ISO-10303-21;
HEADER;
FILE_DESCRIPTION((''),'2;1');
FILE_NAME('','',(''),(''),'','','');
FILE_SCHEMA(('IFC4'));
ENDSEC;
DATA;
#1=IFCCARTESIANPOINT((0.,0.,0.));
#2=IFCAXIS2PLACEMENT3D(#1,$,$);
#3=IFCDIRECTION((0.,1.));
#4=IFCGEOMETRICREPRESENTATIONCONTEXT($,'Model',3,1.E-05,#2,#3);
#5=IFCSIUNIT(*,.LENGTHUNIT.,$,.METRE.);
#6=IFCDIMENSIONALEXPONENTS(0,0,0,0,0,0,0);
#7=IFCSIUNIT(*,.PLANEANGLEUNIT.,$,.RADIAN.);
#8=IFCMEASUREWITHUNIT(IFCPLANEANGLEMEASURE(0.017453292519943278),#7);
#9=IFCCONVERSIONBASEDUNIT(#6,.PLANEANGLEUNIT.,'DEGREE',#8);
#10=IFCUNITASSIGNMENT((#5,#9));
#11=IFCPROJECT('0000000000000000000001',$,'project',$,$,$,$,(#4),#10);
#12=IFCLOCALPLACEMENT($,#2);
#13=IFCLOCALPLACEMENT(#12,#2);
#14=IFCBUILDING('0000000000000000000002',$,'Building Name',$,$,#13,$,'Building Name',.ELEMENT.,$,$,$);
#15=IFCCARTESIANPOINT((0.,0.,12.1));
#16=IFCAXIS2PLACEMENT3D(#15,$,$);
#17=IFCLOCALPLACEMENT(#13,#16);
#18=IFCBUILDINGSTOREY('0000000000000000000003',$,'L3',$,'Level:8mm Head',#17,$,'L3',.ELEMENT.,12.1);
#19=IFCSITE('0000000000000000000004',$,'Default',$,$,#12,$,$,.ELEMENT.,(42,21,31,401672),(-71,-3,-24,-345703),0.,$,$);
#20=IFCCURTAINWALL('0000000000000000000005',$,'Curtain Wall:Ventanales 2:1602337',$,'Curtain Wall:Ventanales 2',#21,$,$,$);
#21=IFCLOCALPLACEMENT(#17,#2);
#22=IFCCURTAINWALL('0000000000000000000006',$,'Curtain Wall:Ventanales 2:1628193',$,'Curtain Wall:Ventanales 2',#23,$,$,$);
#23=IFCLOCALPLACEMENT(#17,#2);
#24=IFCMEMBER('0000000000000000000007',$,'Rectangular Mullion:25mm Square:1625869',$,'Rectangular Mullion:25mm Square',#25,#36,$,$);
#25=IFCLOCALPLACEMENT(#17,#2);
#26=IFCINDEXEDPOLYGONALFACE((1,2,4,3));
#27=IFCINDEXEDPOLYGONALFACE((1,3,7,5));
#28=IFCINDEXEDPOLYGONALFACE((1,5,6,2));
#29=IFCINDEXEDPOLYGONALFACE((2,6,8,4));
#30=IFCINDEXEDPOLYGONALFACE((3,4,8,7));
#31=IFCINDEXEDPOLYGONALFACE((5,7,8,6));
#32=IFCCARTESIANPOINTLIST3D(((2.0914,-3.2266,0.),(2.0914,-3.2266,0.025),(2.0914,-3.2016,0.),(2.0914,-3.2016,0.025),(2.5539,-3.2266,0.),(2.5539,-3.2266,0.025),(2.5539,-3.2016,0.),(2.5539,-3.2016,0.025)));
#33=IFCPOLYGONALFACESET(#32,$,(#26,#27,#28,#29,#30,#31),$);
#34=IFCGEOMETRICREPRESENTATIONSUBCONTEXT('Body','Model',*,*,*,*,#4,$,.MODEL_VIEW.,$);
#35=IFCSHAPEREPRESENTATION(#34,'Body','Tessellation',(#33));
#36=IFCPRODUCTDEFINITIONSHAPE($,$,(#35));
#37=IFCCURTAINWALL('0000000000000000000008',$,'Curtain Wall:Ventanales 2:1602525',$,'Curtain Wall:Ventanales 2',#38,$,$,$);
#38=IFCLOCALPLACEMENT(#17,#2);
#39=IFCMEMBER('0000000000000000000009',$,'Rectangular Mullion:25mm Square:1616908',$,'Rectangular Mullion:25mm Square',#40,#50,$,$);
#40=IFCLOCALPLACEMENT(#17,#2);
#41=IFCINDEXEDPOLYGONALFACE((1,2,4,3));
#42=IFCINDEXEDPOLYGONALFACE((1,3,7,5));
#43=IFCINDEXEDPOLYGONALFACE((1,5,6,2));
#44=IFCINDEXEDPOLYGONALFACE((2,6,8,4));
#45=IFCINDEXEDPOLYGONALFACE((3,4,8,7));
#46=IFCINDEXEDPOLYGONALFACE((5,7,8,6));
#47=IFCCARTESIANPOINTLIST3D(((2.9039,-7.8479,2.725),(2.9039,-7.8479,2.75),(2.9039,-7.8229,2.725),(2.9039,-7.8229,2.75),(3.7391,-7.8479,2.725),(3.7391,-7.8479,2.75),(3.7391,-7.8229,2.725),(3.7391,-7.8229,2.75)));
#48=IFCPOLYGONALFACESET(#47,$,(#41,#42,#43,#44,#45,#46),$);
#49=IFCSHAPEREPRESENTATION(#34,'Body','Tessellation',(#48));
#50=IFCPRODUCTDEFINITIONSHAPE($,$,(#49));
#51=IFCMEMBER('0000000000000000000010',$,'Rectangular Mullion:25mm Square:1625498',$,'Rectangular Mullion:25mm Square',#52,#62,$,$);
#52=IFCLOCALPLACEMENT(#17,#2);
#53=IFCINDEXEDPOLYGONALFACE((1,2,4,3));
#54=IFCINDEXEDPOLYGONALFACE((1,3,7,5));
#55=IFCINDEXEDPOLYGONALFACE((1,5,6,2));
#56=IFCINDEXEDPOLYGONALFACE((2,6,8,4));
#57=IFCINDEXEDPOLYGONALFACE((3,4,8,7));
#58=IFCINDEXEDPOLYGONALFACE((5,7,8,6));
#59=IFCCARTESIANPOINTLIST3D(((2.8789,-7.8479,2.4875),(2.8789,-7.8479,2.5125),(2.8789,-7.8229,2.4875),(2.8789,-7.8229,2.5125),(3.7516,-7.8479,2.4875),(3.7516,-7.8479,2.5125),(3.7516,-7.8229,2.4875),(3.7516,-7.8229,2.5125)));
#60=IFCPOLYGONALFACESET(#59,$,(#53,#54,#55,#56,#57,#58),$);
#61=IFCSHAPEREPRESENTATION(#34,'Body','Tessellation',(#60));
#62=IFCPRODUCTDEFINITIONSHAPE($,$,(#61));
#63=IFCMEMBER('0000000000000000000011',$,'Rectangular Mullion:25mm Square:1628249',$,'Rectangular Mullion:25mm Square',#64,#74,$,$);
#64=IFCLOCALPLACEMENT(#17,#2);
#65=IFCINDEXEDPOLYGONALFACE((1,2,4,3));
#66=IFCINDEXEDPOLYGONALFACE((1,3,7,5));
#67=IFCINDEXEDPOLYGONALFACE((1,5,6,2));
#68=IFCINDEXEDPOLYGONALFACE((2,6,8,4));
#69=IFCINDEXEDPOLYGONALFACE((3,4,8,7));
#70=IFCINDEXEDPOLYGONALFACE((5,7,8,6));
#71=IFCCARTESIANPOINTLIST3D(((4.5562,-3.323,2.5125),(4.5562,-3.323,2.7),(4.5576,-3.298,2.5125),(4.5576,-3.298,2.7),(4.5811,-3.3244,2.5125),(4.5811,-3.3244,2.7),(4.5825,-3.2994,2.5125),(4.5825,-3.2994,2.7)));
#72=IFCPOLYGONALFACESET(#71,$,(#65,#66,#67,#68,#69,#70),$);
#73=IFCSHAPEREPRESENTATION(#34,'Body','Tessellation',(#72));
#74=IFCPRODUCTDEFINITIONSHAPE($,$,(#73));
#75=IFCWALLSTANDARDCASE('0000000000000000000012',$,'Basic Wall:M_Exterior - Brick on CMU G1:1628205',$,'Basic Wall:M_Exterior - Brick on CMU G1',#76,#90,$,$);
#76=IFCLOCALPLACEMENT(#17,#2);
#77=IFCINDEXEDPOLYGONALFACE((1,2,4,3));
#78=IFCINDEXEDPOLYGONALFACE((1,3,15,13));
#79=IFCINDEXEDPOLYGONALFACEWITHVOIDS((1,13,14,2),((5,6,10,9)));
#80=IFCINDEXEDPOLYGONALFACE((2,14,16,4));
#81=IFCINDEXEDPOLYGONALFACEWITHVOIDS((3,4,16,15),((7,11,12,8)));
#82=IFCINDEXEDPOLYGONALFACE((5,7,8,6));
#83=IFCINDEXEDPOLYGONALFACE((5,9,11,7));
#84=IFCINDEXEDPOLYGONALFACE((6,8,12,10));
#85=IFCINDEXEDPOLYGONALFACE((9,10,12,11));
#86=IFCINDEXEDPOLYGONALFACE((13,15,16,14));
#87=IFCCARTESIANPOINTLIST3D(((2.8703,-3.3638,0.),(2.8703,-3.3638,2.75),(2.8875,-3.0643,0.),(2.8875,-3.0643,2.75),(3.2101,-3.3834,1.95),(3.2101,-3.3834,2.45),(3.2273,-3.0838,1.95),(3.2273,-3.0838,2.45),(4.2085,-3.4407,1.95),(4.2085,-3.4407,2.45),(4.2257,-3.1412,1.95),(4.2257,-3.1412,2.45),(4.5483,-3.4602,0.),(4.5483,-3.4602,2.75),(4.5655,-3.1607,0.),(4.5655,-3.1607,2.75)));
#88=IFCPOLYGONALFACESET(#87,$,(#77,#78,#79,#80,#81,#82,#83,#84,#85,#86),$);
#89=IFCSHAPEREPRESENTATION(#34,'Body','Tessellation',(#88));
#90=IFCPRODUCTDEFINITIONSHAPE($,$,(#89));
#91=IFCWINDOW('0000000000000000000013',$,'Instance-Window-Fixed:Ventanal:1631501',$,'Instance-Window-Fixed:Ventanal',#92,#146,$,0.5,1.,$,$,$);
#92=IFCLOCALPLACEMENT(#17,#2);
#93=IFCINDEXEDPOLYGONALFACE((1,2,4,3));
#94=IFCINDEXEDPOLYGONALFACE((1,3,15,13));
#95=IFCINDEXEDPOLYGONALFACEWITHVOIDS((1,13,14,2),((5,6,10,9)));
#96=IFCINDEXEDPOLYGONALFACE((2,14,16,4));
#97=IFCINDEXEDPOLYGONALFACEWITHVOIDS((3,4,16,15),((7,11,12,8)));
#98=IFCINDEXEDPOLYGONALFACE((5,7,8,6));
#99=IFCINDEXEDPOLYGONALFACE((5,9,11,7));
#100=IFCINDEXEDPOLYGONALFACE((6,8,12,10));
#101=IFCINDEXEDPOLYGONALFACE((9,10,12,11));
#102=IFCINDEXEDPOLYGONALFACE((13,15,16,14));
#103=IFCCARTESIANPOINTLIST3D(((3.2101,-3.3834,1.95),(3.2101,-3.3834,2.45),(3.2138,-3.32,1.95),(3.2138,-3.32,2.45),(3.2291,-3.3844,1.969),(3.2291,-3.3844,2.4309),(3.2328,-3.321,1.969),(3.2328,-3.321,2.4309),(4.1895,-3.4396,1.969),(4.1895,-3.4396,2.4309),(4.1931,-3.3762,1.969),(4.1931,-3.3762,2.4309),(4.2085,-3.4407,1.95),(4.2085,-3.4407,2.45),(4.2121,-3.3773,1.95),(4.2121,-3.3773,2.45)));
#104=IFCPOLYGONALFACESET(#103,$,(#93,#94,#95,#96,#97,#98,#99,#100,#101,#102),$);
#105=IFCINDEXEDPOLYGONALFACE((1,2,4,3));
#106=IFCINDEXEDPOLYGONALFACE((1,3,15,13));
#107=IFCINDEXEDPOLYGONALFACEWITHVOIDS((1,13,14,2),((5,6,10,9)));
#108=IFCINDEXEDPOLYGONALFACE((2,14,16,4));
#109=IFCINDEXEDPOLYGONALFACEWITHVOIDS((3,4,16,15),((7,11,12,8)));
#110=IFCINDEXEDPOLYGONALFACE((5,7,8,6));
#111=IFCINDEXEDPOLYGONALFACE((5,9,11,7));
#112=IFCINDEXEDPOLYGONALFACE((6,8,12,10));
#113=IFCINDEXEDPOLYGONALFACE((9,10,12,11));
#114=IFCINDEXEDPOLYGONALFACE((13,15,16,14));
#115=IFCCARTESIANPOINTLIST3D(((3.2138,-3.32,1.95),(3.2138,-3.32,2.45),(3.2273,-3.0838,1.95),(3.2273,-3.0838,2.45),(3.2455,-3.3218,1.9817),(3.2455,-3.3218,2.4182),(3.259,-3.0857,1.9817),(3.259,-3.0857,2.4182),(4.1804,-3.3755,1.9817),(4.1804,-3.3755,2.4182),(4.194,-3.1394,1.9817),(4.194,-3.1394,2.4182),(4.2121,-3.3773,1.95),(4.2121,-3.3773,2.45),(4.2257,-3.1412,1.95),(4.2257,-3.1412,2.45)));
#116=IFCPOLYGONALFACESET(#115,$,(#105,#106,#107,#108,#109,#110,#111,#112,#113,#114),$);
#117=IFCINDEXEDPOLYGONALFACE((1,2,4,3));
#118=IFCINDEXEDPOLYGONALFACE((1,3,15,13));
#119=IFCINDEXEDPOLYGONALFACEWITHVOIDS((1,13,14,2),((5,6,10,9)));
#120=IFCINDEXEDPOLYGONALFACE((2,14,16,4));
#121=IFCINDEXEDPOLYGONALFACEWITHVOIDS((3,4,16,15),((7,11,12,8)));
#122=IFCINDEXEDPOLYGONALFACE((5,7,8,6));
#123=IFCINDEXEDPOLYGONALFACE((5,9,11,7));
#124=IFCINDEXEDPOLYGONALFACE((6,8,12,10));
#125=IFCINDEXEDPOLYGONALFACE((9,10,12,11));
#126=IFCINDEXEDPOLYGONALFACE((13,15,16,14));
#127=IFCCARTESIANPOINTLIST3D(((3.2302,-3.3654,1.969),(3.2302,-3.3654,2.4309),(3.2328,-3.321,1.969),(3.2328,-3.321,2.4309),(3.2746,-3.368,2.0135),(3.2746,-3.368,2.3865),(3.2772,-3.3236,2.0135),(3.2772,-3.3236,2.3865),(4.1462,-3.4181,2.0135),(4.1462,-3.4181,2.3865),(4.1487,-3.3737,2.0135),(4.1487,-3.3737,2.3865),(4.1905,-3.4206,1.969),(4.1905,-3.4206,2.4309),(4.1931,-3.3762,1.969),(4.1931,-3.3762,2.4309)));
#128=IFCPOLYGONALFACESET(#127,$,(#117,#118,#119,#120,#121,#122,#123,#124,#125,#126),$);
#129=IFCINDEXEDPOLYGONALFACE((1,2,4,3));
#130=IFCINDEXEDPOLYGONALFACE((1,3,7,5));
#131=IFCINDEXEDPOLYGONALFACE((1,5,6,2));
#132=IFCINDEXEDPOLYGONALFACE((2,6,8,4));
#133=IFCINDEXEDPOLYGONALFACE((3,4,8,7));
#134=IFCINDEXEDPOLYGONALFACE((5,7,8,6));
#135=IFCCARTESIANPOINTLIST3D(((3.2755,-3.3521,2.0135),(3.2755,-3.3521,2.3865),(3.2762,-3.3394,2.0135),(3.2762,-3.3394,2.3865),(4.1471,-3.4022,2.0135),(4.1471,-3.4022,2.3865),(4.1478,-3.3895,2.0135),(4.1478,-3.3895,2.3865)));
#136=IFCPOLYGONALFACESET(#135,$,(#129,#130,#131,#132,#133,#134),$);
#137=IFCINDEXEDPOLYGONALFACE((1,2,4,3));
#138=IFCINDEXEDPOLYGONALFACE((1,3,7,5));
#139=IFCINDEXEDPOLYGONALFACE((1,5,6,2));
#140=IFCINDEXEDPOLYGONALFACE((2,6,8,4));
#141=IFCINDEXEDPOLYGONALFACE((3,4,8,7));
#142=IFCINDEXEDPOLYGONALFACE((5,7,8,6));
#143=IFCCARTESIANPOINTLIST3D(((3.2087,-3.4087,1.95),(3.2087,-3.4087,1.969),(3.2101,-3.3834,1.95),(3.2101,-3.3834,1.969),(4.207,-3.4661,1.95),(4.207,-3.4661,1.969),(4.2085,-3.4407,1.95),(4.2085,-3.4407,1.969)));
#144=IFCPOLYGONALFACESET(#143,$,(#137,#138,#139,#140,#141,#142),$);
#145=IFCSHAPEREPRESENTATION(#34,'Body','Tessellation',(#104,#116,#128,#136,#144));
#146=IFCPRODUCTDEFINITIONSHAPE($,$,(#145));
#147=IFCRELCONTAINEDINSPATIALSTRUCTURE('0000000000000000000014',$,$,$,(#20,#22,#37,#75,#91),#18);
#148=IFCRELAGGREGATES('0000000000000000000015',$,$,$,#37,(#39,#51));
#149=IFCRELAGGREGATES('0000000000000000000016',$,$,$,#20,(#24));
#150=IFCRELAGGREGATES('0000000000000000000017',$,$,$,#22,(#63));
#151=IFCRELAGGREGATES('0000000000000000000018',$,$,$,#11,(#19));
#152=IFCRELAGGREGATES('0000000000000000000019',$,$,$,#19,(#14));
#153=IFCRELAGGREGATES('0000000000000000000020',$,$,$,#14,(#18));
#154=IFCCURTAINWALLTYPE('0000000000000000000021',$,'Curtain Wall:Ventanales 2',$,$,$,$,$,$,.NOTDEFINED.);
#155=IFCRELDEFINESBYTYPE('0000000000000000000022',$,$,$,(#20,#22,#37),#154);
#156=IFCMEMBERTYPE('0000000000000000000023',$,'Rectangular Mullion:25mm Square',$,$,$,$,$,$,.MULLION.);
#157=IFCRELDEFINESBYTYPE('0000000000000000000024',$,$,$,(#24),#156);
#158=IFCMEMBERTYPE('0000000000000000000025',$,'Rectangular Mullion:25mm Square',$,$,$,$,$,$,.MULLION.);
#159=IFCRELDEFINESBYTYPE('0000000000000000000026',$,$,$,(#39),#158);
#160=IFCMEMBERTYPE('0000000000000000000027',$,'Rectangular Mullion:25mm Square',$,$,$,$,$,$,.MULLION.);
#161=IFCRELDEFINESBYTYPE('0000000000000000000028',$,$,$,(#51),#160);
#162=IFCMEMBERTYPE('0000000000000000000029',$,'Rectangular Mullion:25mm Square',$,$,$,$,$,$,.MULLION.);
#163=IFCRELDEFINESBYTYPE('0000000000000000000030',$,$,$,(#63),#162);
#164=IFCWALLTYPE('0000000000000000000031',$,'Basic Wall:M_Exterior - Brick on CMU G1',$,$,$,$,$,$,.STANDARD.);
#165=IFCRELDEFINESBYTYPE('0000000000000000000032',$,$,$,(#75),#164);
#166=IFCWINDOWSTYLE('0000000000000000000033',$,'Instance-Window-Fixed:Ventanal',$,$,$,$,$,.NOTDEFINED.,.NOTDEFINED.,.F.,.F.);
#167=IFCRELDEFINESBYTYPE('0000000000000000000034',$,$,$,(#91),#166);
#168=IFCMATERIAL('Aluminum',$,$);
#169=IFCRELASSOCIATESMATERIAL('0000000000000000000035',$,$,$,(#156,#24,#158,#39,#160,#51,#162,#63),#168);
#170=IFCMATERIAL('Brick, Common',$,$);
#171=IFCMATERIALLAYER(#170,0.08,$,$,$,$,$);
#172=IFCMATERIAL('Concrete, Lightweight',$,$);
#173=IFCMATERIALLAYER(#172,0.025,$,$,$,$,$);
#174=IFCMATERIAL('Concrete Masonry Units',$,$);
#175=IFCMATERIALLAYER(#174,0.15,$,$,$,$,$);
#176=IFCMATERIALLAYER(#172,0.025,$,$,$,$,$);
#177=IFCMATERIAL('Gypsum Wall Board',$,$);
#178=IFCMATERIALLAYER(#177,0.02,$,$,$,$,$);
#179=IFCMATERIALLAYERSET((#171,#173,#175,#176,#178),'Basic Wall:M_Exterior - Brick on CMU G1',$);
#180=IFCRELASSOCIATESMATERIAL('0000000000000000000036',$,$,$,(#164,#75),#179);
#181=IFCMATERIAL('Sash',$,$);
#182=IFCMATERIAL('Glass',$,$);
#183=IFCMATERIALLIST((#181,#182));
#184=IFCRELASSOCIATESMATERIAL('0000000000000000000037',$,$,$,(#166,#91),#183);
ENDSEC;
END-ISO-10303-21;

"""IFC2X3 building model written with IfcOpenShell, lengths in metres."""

from ifc_helpers import new_model, entity, si_unit, converted_unit, direction, frame, frame_2d, origin, origin_2d_with_axis, place, context, subcontext, project, spatial, polyline, rectangle, outline, extrude, source, transform, mapped, material, material_list, layer, layer_set, layer_usage, type_object, type_shapes, element, fill, aggregate, save


model = new_model("IFC2X3")

# Units and contexts
model_context = context("Model", 3, precision=1e-05, world=origin(), true_north=direction((0.0, 1.0)))
body_context = subcontext(model_context, "Body", "Model", "MODEL_VIEW")
ifc_project = project(units=[si_unit("LENGTHUNIT", "METRE"), converted_unit("PLANEANGLEUNIT", "DEGREE", entity("IfcPlaneAngleMeasure", 0.017453292519943278), si_unit("PLANEANGLEUNIT", "RADIAN"), dimensions=[0, 0, 0, 0, 0, 0, 0])], contexts=[model_context])

# Site, building, storey
site_placement = place(None, origin())
site = spatial("IfcSite", under=ifc_project, at=site_placement, Name="Default", CompositionType="ELEMENT", RefLatitude=(42, 21, 31, 401672), RefLongitude=(-71, -3, -24, -345703), RefElevation=0.0)
building_placement = place(site_placement, origin())
building = spatial("IfcBuilding", under=site, at=building_placement, Name="Building Name", LongName="Building Name", CompositionType="ELEMENT")
storey_placement = place(building_placement, frame((0.0, 0.0, 12.1)))
storey = spatial("IfcBuildingStorey", under=building, at=storey_placement, Name="L3", ObjectType="Level:8mm Head", LongName="L3", CompositionType="ELEMENT", Elevation=12.1)

# Curtain wall
curtain_wall_type = type_object("IfcCurtainWallType", Name="Curtain Wall:Ventanales 2", PredefinedType="NOTDEFINED")
curtain_wall_1_placement = place(storey_placement, frame((0.0, 0.0, -12.1)))
curtain_wall_1 = element("IfcCurtainWall", 1, at=curtain_wall_1_placement, inside=storey, type_object=curtain_wall_type, Name="Curtain Wall:Ventanales 2:1602337", ObjectType="Curtain Wall:Ventanales 2")
ifc_material_1 = material(Name="Aluminum")

# Curtain wall
curtain_wall_2_placement = place(storey_placement, frame((0.0, 0.0, -12.1)))
curtain_wall_2 = element("IfcCurtainWall", 2, at=curtain_wall_2_placement, inside=storey, type_object=curtain_wall_type, Name="Curtain Wall:Ventanales 2:1628193", ObjectType="Curtain Wall:Ventanales 2")

# Member
member_type_1 = type_object("IfcMemberType", Name="Rectangular Mullion:25mm Square", PredefinedType="MULLION", material=ifc_material_1)
shared_shape_1 = source(origin(), body_context, "Body", "SweptSolid", [
    extrude(rectangle(XDim=0.025, YDim=0.025, at=origin_2d_with_axis()), frame((-0.0125, 0.0, -0.4625), z_axis=(0.0, 0.0, 1.0), x_axis=(-1.0, 0.0, 0.0)), (0.0, 0.0, 1.0), 0.4625),
])
type_shapes(member_type_1, [shared_shape_1])
member_1_placement = place(curtain_wall_1_placement, frame((2.0914, -3.2141, 12.1), z_axis=(-1.0, 0.0, 0.0), x_axis=(0.0, 0.0, -1.0)))
member_1 = element("IfcMember", 3, at=member_1_placement, type_object=member_type_1, material=ifc_material_1, Name="Rectangular Mullion:25mm Square:1625869", ObjectType="Rectangular Mullion:25mm Square", context=body_context, shape_type="MappedRepresentation", body=[
    mapped(shared_shape_1, transform((0.0, 0.0, 0.0), scale=1.0)),
])

# Curtain wall, members
curtain_wall_3_placement = place(storey_placement, frame((0.0, 0.0, -12.1)))
curtain_wall_3 = element("IfcCurtainWall", 4, at=curtain_wall_3_placement, inside=storey, type_object=curtain_wall_type, Name="Curtain Wall:Ventanales 2:1602525", ObjectType="Curtain Wall:Ventanales 2")
member_type_2 = type_object("IfcMemberType", Name="Rectangular Mullion:25mm Square", PredefinedType="MULLION", material=ifc_material_1)
shared_shape_2 = source(origin(), body_context, "Body", "SweptSolid", [
    extrude(rectangle(XDim=0.025, YDim=0.025, at=origin_2d_with_axis()), frame((-0.0125, 0.0, -0.8352), z_axis=(0.0, 0.0, 1.0), x_axis=(-1.0, 0.0, 0.0)), (0.0, 0.0, 1.0), 0.8352),
])
type_shapes(member_type_2, [shared_shape_2])
member_2_placement = place(curtain_wall_3_placement, frame((2.9039, -7.8354, 14.85), z_axis=(-1.0, 0.0, 0.0), x_axis=(0.0, 0.0, 1.0)))
member_2 = element("IfcMember", 5, at=member_2_placement, type_object=member_type_2, material=ifc_material_1, Name="Rectangular Mullion:25mm Square:1616908", ObjectType="Rectangular Mullion:25mm Square", context=body_context, shape_type="MappedRepresentation", body=[
    mapped(shared_shape_2, transform((0.0, 0.0, 0.0), scale=1.0)),
])
member_type_3 = type_object("IfcMemberType", Name="Rectangular Mullion:25mm Square", PredefinedType="MULLION", material=ifc_material_1)
shared_shape_3 = source(origin(), body_context, "Body", "SweptSolid", [
    extrude(rectangle(XDim=0.025, YDim=0.025, at=frame_2d((0.0, 0.0), x_axis=(1.0, 0.0))), frame((0.0, 0.0, -0.8727), z_axis=(0.0, 0.0, 1.0), x_axis=(-1.0, 0.0, 0.0)), (0.0, 0.0, 1.0), 0.8727),
])
type_shapes(member_type_3, [shared_shape_3])
member_3_placement = place(curtain_wall_3_placement, frame((2.8789, -7.8354, 14.6), z_axis=(-1.0, 0.0, 0.0), x_axis=(0.0, 0.0, 1.0)))
member_3 = element("IfcMember", 6, at=member_3_placement, type_object=member_type_3, material=ifc_material_1, Name="Rectangular Mullion:25mm Square:1625498", ObjectType="Rectangular Mullion:25mm Square", context=body_context, shape_type="MappedRepresentation", body=[
    mapped(shared_shape_3, transform((0.0, 0.0, 0.0), scale=1.0)),
])
aggregate(curtain_wall_3, [member_2, member_3])

# Member
member_type_4 = type_object("IfcMemberType", Name="Rectangular Mullion:25mm Square", PredefinedType="MULLION", material=ifc_material_1)
shared_shape_4 = source(origin(), body_context, "Body", "SweptSolid", [
    extrude(rectangle(XDim=0.025, YDim=0.025, at=origin_2d_with_axis()), frame((-0.0125, 0.0, -0.1875), z_axis=(0.0, 0.0, 1.0), x_axis=(-1.0, 0.0, 0.0)), (0.0, 0.0, 1.0), 0.1875),
])
type_shapes(member_type_4, [shared_shape_4])
member_4_placement = place(curtain_wall_2_placement, frame((4.5569, -3.3105, 14.8), z_axis=(0.0, 0.0, 1.0), x_axis=(-0.998353, 0.057365, 0.0)))
member_4 = element("IfcMember", 7, at=member_4_placement, type_object=member_type_4, material=ifc_material_1, Name="Rectangular Mullion:25mm Square:1628249", ObjectType="Rectangular Mullion:25mm Square", context=body_context, shape_type="MappedRepresentation", body=[
    mapped(shared_shape_4, transform((0.0, 0.0, 0.0), scale=1.0)),
])

# Shared definitions
ifc_material_2 = material(Name="Glass")
aggregate(curtain_wall_1, [member_1])
aggregate(curtain_wall_2, [member_4])

# Wall, opening, window
ifc_material_3 = material(Name="Brick, Common")
ifc_layer_1 = layer(ifc_material_3, 0.08)
ifc_material_4 = material(Name="Concrete, Lightweight")
ifc_layer_2 = layer(ifc_material_4, 0.025)
ifc_material_5 = material(Name="Concrete Masonry Units")
ifc_layer_3 = layer(ifc_material_5, 0.15)
ifc_layer_4 = layer(ifc_material_4, 0.025)
ifc_material_6 = material(Name="Gypsum Wall Board")
ifc_layer_5 = layer(ifc_material_6, 0.02)
ifc_layer_set = layer_set([ifc_layer_1, ifc_layer_2, ifc_layer_3, ifc_layer_4, ifc_layer_5], Name="Basic Wall:M_Exterior - Brick on CMU G1")
ifc_layer_usage = layer_usage(ifc_layer_set, "AXIS2", "NEGATIVE", 0.15)
wall_type = type_object("IfcWallType", Name="Basic Wall:M_Exterior - Brick on CMU G1", PredefinedType="STANDARD", material=ifc_layer_set)
wall_placement = place(storey_placement, frame((2.8789, -3.2141, 0.0), z_axis=(0.0, 0.0, 1.0), x_axis=(0.998353, -0.057365, 0.0)))
wall = element("IfcWallStandardCase", 8, at=wall_placement, inside=storey, type_object=wall_type, material=ifc_layer_usage, Name="Basic Wall:M_Exterior - Brick on CMU G1:1628205", ObjectType="Basic Wall:M_Exterior - Brick on CMU G1", context=body_context, shape_type="SweptSolid", body=[
    extrude(rectangle(XDim=1.6807, YDim=0.3, at=frame_2d((0.8404, 0.0), x_axis=(-1.0, 0.0))), origin(), (0.0, 0.0, 1.0), 2.75),
])
opening_placement = place(wall_placement, frame((1.3404, 0.15, 1.95)))
opening = element("IfcOpeningElement", 9, at=opening_placement, cuts=wall, ObjectType="Opening", context=body_context, shape_type="SweptSolid", body=[
    extrude(rectangle(XDim=0.5, YDim=1.0, at=frame_2d((0.25, 0.5), x_axis=(-1.0, 0.0))), frame((0.0, 0.0, 0.0), z_axis=(0.0, -1.0, 0.0), x_axis=(0.0, 0.0, 1.0)), (0.0, 0.0, 1.0), 0.3),
])
ifc_material_7 = material(Name="Sash")
ifc_material_list = material_list([ifc_material_7, ifc_material_2])
window_style = type_object("IfcWindowStyle", Name="Instance-Window-Fixed:Ventanal", ConstructionType="NOTDEFINED", OperationType="NOTDEFINED", ParameterTakesPrecedence=False, Sizeable=False, material=ifc_material_list)
shared_shape_5 = source(origin(), body_context, "Body", "SweptSolid", [
    extrude(outline(polyline([(-0.25, -0.5), (0.25, -0.5), (0.25, 0.5), (-0.25, 0.5), (-0.25, -0.5)]), holes=[polyline([(-0.2309, -0.4809), (-0.2309, 0.481), (0.231, 0.481), (0.231, -0.4809), (-0.2309, -0.4809)])]), frame((0.5, 0.2365, 0.25), z_axis=(0.0, 1.0, 0.0), x_axis=(0.0, 0.0, -1.0)), (0.0, 0.0, 1.0), 0.0635),
    extrude(outline(polyline([(-0.5, -0.25), (0.5, -0.25), (0.5, 0.25), (-0.5, 0.25), (-0.5, -0.25)]), holes=[polyline([(-0.4683, -0.2182), (-0.4683, 0.2183), (0.4682, 0.2183), (0.4682, -0.2182), (-0.4683, -0.2182)])]), frame((0.5, 0.0, 0.25), z_axis=(0.0, 1.0, 0.0), x_axis=(1.0, 0.0, 0.0)), (0.0, 0.0, 1.0), 0.2365),
    extrude(outline(polyline([(-0.4809, -0.231), (0.4809, -0.231), (0.4809, 0.231), (-0.4809, 0.231), (-0.4809, -0.231)]), holes=[polyline([(-0.4365, -0.1865), (-0.4365, 0.1865), (0.4365, 0.1865), (0.4365, -0.1865), (-0.4365, -0.1865)])]), frame((0.5, 0.2365, 0.25), z_axis=(0.0, 1.0, 0.0), x_axis=(1.0, 0.0, 0.0)), (0.0, 0.0, 1.0), 0.0444),
    extrude(rectangle(XDim=0.0127, YDim=0.873, at=frame_2d((0.0, 0.0), x_axis=(1.0, 0.0))), frame((0.5, 0.2587, 0.0635), z_axis=(0.0, 0.0, 1.0), x_axis=(0.0, 1.0, 0.0)), (0.0, 0.0, 1.0), 0.373),
    extrude(rectangle(XDim=0.0254, YDim=1.0, at=frame_2d((0.0, 0.0), x_axis=(1.0, 0.0))), frame((0.5, 0.3127, 0.0), z_axis=(0.0, 0.0, 1.0), x_axis=(0.0, -1.0, 0.0)), (0.0, 0.0, 1.0), 0.019),
])
type_shapes(window_style, [shared_shape_5])
window_placement = place(opening_placement, frame((0.0, 0.0, 0.0), z_axis=(0.0, 0.0, 1.0), x_axis=(-1.0, 0.0, 0.0)))
window = element("IfcWindow", 10, at=window_placement, inside=storey, type_object=window_style, material=ifc_material_list, Name="Instance-Window-Fixed:Ventanal:1631501", ObjectType="Instance-Window-Fixed:Ventanal", OverallHeight=0.5, OverallWidth=1.0, context=body_context, shape_type="MappedRepresentation", body=[
    mapped(shared_shape_5, transform((0.0, 0.0, 0.0), scale=1.0)),
])
fill(opening, window)

save(model, "model.ifc")
